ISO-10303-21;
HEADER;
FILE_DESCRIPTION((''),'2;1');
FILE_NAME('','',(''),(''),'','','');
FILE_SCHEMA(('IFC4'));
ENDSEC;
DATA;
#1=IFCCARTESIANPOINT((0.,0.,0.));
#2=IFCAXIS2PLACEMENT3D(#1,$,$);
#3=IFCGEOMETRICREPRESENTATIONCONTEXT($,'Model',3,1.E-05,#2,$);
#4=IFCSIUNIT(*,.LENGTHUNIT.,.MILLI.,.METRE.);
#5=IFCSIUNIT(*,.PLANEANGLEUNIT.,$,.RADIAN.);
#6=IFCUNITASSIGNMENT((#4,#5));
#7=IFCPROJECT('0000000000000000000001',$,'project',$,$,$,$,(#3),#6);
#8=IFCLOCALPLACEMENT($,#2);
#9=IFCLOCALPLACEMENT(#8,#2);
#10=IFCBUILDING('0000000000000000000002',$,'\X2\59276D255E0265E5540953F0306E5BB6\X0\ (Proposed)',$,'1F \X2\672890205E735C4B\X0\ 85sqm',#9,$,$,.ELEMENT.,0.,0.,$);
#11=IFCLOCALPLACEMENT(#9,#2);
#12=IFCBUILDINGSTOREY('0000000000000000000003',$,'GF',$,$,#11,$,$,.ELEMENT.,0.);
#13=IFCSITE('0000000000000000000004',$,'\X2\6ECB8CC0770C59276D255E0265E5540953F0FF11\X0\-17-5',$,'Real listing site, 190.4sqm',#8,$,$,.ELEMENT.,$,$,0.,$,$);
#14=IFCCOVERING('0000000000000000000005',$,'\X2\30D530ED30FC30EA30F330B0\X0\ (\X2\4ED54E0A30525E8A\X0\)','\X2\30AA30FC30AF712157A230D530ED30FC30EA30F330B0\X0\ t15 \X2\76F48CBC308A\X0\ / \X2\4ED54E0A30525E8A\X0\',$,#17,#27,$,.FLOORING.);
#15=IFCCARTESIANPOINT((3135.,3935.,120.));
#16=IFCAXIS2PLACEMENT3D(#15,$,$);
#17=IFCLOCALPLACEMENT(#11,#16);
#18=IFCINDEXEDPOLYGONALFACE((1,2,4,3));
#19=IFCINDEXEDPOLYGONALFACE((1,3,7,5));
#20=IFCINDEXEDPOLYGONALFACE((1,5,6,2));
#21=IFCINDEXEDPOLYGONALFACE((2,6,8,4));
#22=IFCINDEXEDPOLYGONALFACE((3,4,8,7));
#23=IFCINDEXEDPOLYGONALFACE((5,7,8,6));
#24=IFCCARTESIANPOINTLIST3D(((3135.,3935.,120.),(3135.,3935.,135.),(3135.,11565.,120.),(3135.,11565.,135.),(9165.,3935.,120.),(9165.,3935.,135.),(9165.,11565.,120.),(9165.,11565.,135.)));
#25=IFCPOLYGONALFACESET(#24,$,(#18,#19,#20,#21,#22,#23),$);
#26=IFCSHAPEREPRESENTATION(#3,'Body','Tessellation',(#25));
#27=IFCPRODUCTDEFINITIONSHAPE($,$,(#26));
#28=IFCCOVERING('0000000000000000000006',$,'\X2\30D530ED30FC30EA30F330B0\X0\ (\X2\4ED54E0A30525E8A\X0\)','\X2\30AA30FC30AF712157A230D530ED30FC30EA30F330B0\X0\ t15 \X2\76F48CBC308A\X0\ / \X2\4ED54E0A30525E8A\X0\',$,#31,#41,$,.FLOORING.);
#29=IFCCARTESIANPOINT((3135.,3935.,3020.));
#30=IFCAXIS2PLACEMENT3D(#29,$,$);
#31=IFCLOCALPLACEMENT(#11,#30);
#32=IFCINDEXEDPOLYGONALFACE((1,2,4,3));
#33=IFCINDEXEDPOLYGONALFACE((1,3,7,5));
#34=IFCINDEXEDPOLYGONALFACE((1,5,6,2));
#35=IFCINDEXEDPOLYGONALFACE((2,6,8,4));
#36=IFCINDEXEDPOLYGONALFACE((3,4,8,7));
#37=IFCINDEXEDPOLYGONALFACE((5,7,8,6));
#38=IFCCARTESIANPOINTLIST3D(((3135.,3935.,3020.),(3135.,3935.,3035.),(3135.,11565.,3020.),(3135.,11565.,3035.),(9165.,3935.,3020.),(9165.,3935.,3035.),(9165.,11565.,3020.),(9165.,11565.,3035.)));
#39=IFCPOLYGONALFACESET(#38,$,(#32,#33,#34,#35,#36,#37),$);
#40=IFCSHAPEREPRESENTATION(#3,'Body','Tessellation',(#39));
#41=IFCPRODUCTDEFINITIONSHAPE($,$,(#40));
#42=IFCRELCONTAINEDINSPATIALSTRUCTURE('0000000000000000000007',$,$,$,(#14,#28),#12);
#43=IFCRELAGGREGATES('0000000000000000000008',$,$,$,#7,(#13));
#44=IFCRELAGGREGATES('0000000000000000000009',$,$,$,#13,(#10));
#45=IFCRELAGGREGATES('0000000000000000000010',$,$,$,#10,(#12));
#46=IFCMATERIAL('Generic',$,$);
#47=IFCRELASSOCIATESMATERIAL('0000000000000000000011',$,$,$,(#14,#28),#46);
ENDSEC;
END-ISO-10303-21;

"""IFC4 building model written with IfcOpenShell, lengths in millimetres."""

from ifc_helpers import new_model, si_unit, frame, frame_2d, origin, place, context, project, spatial, rectangle, extrude, material, element, save


model = new_model("IFC4")

# Units and contexts
model_context = context("Model", 3, precision=1e-05, world=origin())
ifc_project = project(units=[si_unit("LENGTHUNIT", "METRE", prefix="MILLI"), si_unit("PLANEANGLEUNIT", "RADIAN")], contexts=[model_context])

# Site, building, storey
site_placement = place(None, origin())
site = spatial("IfcSite", under=ifc_project, at=site_placement, Name="滋賀県大津市日吉台１-17-5", ObjectType="Real listing site, 190.4sqm", CompositionType="ELEMENT", RefElevation=0.0)
building_placement = place(site_placement, origin())
building = spatial("IfcBuilding", under=site, at=building_placement, Name="大津市日吉台の家 (Proposed)", ObjectType="1F 木造平屋 85sqm", CompositionType="ELEMENT", ElevationOfRefHeight=0.0, ElevationOfTerrain=0.0)
storey_placement = place(building_placement, origin())
storey = spatial("IfcBuildingStorey", under=building, at=storey_placement, Name="GF", CompositionType="ELEMENT", Elevation=0.0)

# Shared definitions
ifc_material_1 = material(Name="Generic")

# Coverings
covering_1_placement = place(storey_placement, frame((3135.0, 3935.0, 120.0)))
element("IfcCovering", 1, at=covering_1_placement, inside=storey, material=ifc_material_1, Name="フローリング (仕上げ床)", Description="オーク無垢フローリング t15 直貼り / 仕上げ床", PredefinedType="FLOORING", context=model_context, shape_type="SweptSolid", body=[
    extrude(rectangle(XDim=6030.0, YDim=7630.0, at=frame_2d((3015.0, 3815.0))), frame((3135.0, 3935.0, 120.0)), (0.0, 0.0, 1.0), 15.0),
])
covering_2_placement = place(storey_placement, frame((3135.0, 3935.0, 3020.0)))
element("IfcCovering", 2, at=covering_2_placement, inside=storey, material=ifc_material_1, Name="フローリング (仕上げ床)", Description="オーク無垢フローリング t15 直貼り / 仕上げ床", PredefinedType="FLOORING", context=model_context, shape_type="SweptSolid", body=[
    extrude(rectangle(XDim=6030.0, YDim=7630.0, at=frame_2d((3015.0, 3815.0))), frame((3135.0, 3935.0, 3020.0)), (0.0, 0.0, 1.0), 15.0),
])

save(model, "model.ifc")
